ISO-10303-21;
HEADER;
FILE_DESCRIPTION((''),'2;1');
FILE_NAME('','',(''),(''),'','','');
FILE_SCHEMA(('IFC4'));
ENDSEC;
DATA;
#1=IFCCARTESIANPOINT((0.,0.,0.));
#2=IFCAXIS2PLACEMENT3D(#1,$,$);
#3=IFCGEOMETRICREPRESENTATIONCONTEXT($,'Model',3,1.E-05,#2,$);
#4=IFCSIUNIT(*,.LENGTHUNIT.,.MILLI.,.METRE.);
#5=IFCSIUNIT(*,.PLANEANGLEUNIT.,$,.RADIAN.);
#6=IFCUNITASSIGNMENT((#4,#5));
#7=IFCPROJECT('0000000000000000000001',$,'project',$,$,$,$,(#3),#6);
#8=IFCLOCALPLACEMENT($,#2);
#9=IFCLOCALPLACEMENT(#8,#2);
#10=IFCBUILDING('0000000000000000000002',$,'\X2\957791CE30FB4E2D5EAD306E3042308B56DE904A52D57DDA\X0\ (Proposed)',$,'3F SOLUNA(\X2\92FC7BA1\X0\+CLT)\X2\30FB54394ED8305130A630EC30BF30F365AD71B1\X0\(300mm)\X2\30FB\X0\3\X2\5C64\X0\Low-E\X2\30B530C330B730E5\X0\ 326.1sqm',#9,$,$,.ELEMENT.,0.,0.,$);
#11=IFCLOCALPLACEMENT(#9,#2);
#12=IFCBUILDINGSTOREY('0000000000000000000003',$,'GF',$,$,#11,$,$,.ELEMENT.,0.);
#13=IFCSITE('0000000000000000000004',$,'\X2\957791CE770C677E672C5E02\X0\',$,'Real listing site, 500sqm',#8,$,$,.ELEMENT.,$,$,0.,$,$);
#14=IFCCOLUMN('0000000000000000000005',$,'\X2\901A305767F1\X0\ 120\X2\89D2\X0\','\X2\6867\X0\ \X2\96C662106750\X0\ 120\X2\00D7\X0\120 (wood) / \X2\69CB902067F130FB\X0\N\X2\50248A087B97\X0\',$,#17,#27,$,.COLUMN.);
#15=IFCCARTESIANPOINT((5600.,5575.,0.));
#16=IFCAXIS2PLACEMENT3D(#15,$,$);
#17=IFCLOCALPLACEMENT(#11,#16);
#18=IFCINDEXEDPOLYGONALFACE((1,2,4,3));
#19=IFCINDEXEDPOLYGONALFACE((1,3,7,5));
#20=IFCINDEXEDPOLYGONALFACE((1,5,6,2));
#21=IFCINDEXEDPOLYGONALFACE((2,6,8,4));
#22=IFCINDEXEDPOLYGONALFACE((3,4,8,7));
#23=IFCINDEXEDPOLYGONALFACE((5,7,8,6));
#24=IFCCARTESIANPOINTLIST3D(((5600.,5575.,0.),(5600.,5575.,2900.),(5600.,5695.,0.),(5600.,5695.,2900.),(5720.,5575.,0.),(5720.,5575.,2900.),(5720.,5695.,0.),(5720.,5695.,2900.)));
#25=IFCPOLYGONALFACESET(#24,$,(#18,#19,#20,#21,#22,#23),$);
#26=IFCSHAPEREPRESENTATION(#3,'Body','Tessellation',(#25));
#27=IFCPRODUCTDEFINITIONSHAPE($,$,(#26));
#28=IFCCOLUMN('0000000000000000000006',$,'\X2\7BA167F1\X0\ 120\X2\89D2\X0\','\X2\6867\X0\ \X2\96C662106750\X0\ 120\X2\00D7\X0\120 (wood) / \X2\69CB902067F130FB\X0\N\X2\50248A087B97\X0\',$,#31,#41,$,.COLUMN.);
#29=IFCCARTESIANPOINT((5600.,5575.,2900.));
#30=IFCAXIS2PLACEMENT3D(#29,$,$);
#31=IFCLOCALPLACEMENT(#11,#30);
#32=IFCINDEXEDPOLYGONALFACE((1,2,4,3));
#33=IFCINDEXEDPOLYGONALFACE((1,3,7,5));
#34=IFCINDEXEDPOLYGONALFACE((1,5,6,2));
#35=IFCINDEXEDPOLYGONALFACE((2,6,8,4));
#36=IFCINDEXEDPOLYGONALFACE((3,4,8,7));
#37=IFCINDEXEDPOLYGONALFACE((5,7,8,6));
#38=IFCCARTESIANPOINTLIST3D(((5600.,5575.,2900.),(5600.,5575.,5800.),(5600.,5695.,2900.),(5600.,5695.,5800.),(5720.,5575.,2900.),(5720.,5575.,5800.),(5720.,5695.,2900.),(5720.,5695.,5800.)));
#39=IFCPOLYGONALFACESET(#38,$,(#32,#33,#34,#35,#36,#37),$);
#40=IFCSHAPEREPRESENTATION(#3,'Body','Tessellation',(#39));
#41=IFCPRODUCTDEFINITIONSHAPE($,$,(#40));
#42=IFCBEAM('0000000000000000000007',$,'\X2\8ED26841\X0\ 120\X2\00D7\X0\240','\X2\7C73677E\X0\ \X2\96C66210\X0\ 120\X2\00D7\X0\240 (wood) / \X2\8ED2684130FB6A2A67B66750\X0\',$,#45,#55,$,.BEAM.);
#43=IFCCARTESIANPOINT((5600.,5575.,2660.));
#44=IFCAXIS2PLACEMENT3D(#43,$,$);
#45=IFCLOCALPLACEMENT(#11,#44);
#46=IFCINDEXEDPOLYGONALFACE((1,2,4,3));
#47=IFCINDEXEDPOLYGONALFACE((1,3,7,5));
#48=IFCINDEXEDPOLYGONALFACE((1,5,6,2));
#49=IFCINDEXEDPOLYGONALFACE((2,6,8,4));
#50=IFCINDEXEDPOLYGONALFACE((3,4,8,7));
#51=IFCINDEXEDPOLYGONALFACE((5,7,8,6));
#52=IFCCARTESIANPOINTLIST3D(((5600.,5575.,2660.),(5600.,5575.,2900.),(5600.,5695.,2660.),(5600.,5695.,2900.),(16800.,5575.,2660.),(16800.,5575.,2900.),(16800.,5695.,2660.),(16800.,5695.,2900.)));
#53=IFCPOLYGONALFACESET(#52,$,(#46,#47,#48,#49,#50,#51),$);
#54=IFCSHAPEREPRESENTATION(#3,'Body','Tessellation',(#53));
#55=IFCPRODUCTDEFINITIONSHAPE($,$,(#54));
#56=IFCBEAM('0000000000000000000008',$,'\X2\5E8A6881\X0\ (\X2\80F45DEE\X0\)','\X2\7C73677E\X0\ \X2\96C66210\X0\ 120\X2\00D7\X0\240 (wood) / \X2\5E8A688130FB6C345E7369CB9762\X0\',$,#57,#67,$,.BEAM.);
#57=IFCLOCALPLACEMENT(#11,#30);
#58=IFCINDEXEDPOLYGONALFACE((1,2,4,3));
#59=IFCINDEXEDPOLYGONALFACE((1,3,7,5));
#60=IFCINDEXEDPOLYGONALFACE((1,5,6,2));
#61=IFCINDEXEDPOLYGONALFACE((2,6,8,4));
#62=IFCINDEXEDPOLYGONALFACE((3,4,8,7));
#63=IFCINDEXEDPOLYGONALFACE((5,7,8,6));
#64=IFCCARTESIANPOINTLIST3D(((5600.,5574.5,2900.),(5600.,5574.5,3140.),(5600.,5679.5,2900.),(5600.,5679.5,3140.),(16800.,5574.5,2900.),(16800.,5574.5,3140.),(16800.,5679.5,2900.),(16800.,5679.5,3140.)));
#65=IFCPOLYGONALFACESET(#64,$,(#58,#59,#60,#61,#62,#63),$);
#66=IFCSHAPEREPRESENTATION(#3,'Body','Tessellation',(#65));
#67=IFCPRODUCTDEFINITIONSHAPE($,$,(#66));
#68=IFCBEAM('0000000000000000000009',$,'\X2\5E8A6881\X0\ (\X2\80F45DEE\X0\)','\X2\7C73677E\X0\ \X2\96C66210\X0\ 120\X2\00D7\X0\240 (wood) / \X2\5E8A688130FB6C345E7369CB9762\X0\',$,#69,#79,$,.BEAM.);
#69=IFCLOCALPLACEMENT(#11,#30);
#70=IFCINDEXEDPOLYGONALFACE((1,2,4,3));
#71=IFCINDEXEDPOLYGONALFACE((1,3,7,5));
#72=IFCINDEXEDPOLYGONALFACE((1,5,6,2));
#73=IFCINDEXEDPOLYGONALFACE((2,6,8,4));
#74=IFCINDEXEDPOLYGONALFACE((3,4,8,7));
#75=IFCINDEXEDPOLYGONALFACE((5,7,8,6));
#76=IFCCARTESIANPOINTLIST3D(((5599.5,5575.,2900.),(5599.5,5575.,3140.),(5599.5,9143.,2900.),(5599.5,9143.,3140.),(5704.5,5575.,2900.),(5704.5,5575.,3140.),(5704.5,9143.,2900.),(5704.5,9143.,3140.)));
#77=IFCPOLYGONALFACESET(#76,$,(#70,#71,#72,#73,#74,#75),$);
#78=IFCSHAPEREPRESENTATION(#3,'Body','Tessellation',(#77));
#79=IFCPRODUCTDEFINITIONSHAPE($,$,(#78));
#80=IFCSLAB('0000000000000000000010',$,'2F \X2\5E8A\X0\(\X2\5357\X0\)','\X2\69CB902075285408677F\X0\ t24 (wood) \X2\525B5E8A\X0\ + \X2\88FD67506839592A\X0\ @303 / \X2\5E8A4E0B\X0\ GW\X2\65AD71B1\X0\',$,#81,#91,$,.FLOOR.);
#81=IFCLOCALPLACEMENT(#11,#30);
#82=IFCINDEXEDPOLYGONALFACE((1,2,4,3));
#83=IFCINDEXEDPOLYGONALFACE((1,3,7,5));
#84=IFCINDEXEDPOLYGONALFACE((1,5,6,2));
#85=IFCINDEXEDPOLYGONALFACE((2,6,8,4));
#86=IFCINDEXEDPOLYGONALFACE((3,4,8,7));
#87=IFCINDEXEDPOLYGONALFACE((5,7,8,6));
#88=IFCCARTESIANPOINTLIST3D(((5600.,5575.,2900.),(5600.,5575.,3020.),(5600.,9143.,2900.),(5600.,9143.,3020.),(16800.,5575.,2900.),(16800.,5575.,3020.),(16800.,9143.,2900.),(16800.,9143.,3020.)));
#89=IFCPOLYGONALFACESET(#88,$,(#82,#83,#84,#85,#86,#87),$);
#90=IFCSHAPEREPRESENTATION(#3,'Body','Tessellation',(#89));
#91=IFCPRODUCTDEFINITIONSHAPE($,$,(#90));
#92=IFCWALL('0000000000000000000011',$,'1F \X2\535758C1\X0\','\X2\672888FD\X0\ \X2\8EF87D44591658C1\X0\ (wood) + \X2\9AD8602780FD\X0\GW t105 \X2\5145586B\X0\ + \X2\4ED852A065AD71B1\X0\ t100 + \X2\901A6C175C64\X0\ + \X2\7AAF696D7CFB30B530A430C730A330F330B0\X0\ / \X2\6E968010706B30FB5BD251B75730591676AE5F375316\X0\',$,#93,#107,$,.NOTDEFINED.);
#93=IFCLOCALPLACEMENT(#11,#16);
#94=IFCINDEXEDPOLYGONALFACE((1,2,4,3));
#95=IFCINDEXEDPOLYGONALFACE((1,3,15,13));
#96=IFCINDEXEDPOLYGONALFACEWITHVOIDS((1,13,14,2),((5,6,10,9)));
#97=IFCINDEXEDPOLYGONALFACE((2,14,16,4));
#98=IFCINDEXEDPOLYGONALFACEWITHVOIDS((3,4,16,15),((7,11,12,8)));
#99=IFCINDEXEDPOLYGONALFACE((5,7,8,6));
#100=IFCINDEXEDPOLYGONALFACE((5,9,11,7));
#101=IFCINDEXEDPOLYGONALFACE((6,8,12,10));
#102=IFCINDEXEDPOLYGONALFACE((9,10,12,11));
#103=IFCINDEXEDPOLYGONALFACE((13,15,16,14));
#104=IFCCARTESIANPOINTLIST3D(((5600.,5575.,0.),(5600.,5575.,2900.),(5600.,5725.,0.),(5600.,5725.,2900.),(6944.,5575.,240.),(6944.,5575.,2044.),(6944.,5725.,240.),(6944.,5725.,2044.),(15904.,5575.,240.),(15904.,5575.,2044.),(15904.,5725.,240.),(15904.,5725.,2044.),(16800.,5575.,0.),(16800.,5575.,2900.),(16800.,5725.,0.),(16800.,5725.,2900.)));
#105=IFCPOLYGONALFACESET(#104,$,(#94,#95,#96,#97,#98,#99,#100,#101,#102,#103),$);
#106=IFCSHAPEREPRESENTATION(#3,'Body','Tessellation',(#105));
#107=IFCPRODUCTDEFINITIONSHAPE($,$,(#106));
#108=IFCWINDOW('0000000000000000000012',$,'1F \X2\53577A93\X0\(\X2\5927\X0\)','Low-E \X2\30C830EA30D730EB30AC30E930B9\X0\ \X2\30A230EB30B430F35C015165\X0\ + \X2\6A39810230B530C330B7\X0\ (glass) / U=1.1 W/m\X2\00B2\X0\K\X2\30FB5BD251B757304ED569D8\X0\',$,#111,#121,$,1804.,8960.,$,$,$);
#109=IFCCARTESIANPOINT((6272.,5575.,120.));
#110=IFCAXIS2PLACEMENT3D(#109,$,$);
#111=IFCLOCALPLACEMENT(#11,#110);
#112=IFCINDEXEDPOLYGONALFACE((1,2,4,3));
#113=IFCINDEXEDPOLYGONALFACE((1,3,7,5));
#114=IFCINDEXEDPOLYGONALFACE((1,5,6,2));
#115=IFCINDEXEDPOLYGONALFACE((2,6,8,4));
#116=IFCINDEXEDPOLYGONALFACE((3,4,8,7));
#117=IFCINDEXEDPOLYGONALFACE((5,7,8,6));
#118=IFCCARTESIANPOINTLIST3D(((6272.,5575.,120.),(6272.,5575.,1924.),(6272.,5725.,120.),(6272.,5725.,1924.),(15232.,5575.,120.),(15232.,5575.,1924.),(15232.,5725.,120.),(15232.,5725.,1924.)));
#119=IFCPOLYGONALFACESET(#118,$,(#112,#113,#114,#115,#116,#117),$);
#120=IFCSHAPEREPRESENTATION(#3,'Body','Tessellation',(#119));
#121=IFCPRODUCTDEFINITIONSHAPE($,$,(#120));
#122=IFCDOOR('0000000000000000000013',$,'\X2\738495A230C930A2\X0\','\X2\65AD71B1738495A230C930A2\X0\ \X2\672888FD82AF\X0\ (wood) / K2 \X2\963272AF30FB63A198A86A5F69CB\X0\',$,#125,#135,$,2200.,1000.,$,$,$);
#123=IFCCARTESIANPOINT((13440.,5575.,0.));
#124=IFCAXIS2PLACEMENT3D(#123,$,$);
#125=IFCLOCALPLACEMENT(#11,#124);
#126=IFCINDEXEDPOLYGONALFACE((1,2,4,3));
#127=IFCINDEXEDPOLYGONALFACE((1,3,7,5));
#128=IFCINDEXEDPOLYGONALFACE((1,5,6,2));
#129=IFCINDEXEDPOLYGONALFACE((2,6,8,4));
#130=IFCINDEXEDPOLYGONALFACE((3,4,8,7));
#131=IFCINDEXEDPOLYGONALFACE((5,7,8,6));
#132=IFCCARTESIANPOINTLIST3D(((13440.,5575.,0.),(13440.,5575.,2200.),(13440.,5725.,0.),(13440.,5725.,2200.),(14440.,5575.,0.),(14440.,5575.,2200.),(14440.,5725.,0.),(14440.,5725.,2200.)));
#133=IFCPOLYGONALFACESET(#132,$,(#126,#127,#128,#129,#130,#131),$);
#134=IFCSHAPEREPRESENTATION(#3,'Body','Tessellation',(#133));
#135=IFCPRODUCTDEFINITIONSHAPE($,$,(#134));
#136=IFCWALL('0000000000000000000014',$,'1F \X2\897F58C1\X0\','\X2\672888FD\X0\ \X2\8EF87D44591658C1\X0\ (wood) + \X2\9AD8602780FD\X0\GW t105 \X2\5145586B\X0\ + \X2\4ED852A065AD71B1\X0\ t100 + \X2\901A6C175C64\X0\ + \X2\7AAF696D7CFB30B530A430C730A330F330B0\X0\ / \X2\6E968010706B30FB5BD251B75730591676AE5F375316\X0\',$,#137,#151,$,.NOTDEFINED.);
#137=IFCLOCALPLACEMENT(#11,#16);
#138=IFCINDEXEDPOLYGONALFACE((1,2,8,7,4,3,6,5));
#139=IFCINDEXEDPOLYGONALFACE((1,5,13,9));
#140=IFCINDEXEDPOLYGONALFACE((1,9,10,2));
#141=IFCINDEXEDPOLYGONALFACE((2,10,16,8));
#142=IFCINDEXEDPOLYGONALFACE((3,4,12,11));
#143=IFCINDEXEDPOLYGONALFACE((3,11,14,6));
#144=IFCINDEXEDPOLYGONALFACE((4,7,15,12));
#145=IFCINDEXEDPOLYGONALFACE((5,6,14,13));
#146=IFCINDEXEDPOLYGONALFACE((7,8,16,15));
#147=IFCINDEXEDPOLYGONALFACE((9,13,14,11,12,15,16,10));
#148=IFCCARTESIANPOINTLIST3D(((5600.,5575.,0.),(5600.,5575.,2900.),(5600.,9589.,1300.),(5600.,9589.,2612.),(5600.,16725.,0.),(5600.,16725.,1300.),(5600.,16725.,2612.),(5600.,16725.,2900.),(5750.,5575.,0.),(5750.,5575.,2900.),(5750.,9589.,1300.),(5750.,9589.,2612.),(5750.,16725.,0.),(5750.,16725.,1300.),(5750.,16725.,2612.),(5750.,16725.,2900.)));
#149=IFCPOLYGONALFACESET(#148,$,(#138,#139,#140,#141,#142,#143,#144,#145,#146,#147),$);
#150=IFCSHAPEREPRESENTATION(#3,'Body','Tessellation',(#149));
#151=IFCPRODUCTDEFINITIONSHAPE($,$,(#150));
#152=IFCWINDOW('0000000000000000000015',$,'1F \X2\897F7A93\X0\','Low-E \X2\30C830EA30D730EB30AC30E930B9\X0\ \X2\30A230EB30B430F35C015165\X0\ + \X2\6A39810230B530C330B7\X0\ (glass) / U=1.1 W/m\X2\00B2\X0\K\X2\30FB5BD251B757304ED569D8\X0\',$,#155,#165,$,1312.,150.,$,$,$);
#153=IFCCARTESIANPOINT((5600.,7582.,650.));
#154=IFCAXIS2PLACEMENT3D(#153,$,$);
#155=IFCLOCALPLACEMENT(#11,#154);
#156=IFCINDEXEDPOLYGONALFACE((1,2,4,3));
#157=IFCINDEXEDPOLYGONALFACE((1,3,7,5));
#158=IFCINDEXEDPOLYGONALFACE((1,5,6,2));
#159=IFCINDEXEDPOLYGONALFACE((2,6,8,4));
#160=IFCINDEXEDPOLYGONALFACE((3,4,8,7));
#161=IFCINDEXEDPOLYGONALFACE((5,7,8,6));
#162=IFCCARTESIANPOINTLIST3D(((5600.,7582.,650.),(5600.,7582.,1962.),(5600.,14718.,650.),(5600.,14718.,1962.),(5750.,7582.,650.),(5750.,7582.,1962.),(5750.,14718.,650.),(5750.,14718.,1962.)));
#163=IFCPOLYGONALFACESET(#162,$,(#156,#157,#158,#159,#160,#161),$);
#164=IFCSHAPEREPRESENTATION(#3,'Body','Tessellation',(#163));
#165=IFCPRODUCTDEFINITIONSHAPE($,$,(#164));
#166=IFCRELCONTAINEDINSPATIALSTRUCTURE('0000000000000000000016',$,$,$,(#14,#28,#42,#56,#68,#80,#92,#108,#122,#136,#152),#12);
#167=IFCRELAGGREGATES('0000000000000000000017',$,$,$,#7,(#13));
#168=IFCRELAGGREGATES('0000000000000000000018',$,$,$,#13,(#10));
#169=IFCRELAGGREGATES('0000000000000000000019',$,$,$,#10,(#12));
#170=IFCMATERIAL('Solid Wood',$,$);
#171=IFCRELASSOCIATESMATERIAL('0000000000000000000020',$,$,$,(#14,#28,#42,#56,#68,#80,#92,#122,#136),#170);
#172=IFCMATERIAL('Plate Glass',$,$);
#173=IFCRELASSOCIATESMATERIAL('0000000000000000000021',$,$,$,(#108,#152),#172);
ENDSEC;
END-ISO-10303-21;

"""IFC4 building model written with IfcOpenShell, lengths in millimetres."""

from ifc_helpers import new_model, si_unit, frame, frame_2d, origin, place, context, project, spatial, rectangle, extrude, material, element, fill, save


model = new_model("IFC4")

# Units and contexts
model_context = context("Model", 3, precision=1e-05, world=origin())
ifc_project = project(units=[si_unit("LENGTHUNIT", "METRE", prefix="MILLI"), si_unit("PLANEANGLEUNIT", "RADIAN")], contexts=[model_context])

# Site, building, storey
site_placement = place(None, origin())
site = spatial("IfcSite", under=ifc_project, at=site_placement, Name="長野県松本市", ObjectType="Real listing site, 500sqm", CompositionType="ELEMENT", RefElevation=0.0)
building_placement = place(site_placement, origin())
building = spatial("IfcBuilding", under=site, at=building_placement, Name="長野・中庭のある回遊動線 (Proposed)", ObjectType="3F SOLUNA(鋼管+CLT)・吹付けウレタン断熱(300mm)・3層Low-Eサッシュ 326.1sqm", CompositionType="ELEMENT", ElevationOfRefHeight=0.0, ElevationOfTerrain=0.0)
storey_placement = place(building_placement, origin())
storey = spatial("IfcBuildingStorey", under=building, at=storey_placement, Name="GF", CompositionType="ELEMENT", Elevation=0.0)

# Columns
ifc_material_1 = material(Name="Solid Wood")
column_1_placement = place(storey_placement, frame((5600.0, 5575.0, 0.0)))
element("IfcColumn", 1, at=column_1_placement, inside=storey, material=ifc_material_1, Name="通し柱 120角", Description="桧 集成材 120×120 (wood) / 構造柱・N値計算", PredefinedType="COLUMN", context=model_context, shape_type="SweptSolid", body=[
    extrude(rectangle(XDim=120.0, YDim=120.0, at=frame_2d((60.0, 60.0))), frame((5600.0, 5575.0, 0.0)), (0.0, 0.0, 1.0), 2900.0),
])
column_2_placement = place(storey_placement, frame((5600.0, 5575.0, 2900.0)))
element("IfcColumn", 2, at=column_2_placement, inside=storey, material=ifc_material_1, Name="管柱 120角", Description="桧 集成材 120×120 (wood) / 構造柱・N値計算", PredefinedType="COLUMN", context=model_context, shape_type="SweptSolid", body=[
    extrude(rectangle(XDim=120.0, YDim=120.0, at=frame_2d((60.0, 60.0))), frame((5600.0, 5575.0, 2900.0)), (0.0, 0.0, 1.0), 2900.0),
])

# Beams
beam_1_placement = place(storey_placement, frame((5600.0, 5575.0, 2660.0)))
element("IfcBeam", 3, at=beam_1_placement, inside=storey, material=ifc_material_1, Name="軒桁 120×240", Description="米松 集成 120×240 (wood) / 軒桁・横架材", PredefinedType="BEAM", context=model_context, shape_type="SweptSolid", body=[
    extrude(rectangle(XDim=11200.0, YDim=120.0, at=frame_2d((5600.0, 60.0))), frame((5600.0, 5575.0, 2660.0)), (0.0, 0.0, 1.0), 240.0),
])
beam_2_placement = place(storey_placement, frame((5600.0, 5575.0, 2900.0)))
element("IfcBeam", 4, at=beam_2_placement, inside=storey, material=ifc_material_1, Name="床梁 (胴差)", Description="米松 集成 120×240 (wood) / 床梁・水平構面", PredefinedType="BEAM", context=model_context, shape_type="SweptSolid", body=[
    extrude(rectangle(XDim=11200.0, YDim=105.0, at=frame_2d((5600.0, 52.0))), frame((5600.0, 5575.0, 2900.0)), (0.0, 0.0, 1.0), 240.0),
])
beam_3_placement = place(storey_placement, frame((5600.0, 5575.0, 2900.0)))
element("IfcBeam", 5, at=beam_3_placement, inside=storey, material=ifc_material_1, Name="床梁 (胴差)", Description="米松 集成 120×240 (wood) / 床梁・水平構面", PredefinedType="BEAM", context=model_context, shape_type="SweptSolid", body=[
    extrude(rectangle(XDim=105.0, YDim=3568.0, at=frame_2d((52.0, 1784.0))), frame((5600.0, 5575.0, 2900.0)), (0.0, 0.0, 1.0), 240.0),
])

# Slab
slab_1_placement = place(storey_placement, frame((5600.0, 5575.0, 2900.0)))
element("IfcSlab", 6, at=slab_1_placement, inside=storey, material=ifc_material_1, Name="2F 床(南)", Description="構造用合板 t24 (wood) 剛床 + 製材根太 @303 / 床下 GW断熱", PredefinedType="FLOOR", context=model_context, shape_type="SweptSolid", body=[
    extrude(rectangle(XDim=11200.0, YDim=3568.0, at=frame_2d((5600.0, 1784.0))), frame((5600.0, 5575.0, 2900.0)), (0.0, 0.0, 1.0), 120.0),
])

# Wall, openings, window, door
wall_1_placement = place(storey_placement, frame((5600.0, 5575.0, 0.0)))
wall_1 = element("IfcWall", 7, at=wall_1_placement, inside=storey, material=ifc_material_1, Name="1F 南壁", Description="木製 軸組外壁 (wood) + 高性能GW t105 充填 + 付加断熱 t100 + 通気層 + 窯業系サイディング / 準耐火・寒冷地外皮強化", PredefinedType="NOTDEFINED", context=model_context, shape_type="SweptSolid", body=[
    extrude(rectangle(XDim=11200.0, YDim=150.0, at=frame_2d((5600.0, 75.0))), frame((5600.0, 5575.0, 0.0)), (0.0, 0.0, 1.0), 2900.0),
])
opening_1_placement = place(storey_placement, frame((6272.0, 5575.0, 120.0)))
opening_1 = element("IfcOpeningElement", 8, at=opening_1_placement, cuts=wall_1, PredefinedType="NOTDEFINED", context=model_context, shape_type="SweptSolid", body=[
    extrude(rectangle(XDim=8960.0, YDim=150.0, at=frame_2d((4480.0, 75.0))), frame((6272.0, 5575.0, 120.0)), (0.0, 0.0, 1.0), 1804.0),
])
opening_2_placement = place(storey_placement, frame((13440.0, 5575.0, 0.0)))
opening_2 = element("IfcOpeningElement", 9, at=opening_2_placement, cuts=wall_1, PredefinedType="NOTDEFINED", context=model_context, shape_type="SweptSolid", body=[
    extrude(rectangle(XDim=1000.0, YDim=150.0, at=frame_2d((500.0, 75.0))), frame((13440.0, 5575.0, 0.0)), (0.0, 0.0, 1.0), 2200.0),
])
ifc_material_2 = material(Name="Plate Glass")
window_1_placement = place(storey_placement, frame((6272.0, 5575.0, 120.0)))
window_1 = element("IfcWindow", 10, at=window_1_placement, inside=storey, material=ifc_material_2, Name="1F 南窓(大)", Description="Low-E トリプルガラス アルゴン封入 + 樹脂サッシ (glass) / U=1.1 W/m²K・寒冷地仕様", OverallHeight=1804.0, OverallWidth=8960.0, context=model_context, shape_type="SweptSolid", body=[
    extrude(rectangle(XDim=8960.0, YDim=150.0, at=frame_2d((4480.0, 75.0))), frame((6272.0, 5575.0, 120.0)), (0.0, 0.0, 1.0), 1804.0),
])
fill(opening_1, window_1)
door_placement = place(storey_placement, frame((13440.0, 5575.0, 0.0)))
door = element("IfcDoor", 11, at=door_placement, inside=storey, material=ifc_material_1, Name="玄関ドア", Description="断熱玄関ドア 木製芯 (wood) / K2 防犯・採風機構", OverallHeight=2200.0, OverallWidth=1000.0, context=model_context, shape_type="SweptSolid", body=[
    extrude(rectangle(XDim=1000.0, YDim=150.0, at=frame_2d((500.0, 75.0))), frame((13440.0, 5575.0, 0.0)), (0.0, 0.0, 1.0), 2200.0),
])
fill(opening_2, door)

# Wall, opening, window
wall_2_placement = place(storey_placement, frame((5600.0, 5575.0, 0.0)))
wall_2 = element("IfcWall", 12, at=wall_2_placement, inside=storey, material=ifc_material_1, Name="1F 西壁", Description="木製 軸組外壁 (wood) + 高性能GW t105 充填 + 付加断熱 t100 + 通気層 + 窯業系サイディング / 準耐火・寒冷地外皮強化", PredefinedType="NOTDEFINED", context=model_context, shape_type="SweptSolid", body=[
    extrude(rectangle(XDim=150.0, YDim=11150.0, at=frame_2d((75.0, 5575.0))), frame((5600.0, 5575.0, 0.0)), (0.0, 0.0, 1.0), 2900.0),
])
opening_3_placement = place(storey_placement, frame((5600.0, 7582.0, 650.0)))
opening_3 = element("IfcOpeningElement", 13, at=opening_3_placement, cuts=wall_2, PredefinedType="NOTDEFINED", context=model_context, shape_type="SweptSolid", body=[
    extrude(rectangle(XDim=150.0, YDim=7136.0, at=frame_2d((75.0, 3568.0))), frame((5600.0, 7582.0, 650.0)), (0.0, 0.0, 1.0), 1312.0),
])
window_2_placement = place(storey_placement, frame((5600.0, 7582.0, 650.0)))
window_2 = element("IfcWindow", 14, at=window_2_placement, inside=storey, material=ifc_material_2, Name="1F 西窓", Description="Low-E トリプルガラス アルゴン封入 + 樹脂サッシ (glass) / U=1.1 W/m²K・寒冷地仕様", OverallHeight=1312.0, OverallWidth=150.0, context=model_context, shape_type="SweptSolid", body=[
    extrude(rectangle(XDim=150.0, YDim=7136.0, at=frame_2d((75.0, 3568.0))), frame((5600.0, 7582.0, 650.0)), (0.0, 0.0, 1.0), 1312.0),
])
fill(opening_3, window_2)

save(model, "model.ifc")
